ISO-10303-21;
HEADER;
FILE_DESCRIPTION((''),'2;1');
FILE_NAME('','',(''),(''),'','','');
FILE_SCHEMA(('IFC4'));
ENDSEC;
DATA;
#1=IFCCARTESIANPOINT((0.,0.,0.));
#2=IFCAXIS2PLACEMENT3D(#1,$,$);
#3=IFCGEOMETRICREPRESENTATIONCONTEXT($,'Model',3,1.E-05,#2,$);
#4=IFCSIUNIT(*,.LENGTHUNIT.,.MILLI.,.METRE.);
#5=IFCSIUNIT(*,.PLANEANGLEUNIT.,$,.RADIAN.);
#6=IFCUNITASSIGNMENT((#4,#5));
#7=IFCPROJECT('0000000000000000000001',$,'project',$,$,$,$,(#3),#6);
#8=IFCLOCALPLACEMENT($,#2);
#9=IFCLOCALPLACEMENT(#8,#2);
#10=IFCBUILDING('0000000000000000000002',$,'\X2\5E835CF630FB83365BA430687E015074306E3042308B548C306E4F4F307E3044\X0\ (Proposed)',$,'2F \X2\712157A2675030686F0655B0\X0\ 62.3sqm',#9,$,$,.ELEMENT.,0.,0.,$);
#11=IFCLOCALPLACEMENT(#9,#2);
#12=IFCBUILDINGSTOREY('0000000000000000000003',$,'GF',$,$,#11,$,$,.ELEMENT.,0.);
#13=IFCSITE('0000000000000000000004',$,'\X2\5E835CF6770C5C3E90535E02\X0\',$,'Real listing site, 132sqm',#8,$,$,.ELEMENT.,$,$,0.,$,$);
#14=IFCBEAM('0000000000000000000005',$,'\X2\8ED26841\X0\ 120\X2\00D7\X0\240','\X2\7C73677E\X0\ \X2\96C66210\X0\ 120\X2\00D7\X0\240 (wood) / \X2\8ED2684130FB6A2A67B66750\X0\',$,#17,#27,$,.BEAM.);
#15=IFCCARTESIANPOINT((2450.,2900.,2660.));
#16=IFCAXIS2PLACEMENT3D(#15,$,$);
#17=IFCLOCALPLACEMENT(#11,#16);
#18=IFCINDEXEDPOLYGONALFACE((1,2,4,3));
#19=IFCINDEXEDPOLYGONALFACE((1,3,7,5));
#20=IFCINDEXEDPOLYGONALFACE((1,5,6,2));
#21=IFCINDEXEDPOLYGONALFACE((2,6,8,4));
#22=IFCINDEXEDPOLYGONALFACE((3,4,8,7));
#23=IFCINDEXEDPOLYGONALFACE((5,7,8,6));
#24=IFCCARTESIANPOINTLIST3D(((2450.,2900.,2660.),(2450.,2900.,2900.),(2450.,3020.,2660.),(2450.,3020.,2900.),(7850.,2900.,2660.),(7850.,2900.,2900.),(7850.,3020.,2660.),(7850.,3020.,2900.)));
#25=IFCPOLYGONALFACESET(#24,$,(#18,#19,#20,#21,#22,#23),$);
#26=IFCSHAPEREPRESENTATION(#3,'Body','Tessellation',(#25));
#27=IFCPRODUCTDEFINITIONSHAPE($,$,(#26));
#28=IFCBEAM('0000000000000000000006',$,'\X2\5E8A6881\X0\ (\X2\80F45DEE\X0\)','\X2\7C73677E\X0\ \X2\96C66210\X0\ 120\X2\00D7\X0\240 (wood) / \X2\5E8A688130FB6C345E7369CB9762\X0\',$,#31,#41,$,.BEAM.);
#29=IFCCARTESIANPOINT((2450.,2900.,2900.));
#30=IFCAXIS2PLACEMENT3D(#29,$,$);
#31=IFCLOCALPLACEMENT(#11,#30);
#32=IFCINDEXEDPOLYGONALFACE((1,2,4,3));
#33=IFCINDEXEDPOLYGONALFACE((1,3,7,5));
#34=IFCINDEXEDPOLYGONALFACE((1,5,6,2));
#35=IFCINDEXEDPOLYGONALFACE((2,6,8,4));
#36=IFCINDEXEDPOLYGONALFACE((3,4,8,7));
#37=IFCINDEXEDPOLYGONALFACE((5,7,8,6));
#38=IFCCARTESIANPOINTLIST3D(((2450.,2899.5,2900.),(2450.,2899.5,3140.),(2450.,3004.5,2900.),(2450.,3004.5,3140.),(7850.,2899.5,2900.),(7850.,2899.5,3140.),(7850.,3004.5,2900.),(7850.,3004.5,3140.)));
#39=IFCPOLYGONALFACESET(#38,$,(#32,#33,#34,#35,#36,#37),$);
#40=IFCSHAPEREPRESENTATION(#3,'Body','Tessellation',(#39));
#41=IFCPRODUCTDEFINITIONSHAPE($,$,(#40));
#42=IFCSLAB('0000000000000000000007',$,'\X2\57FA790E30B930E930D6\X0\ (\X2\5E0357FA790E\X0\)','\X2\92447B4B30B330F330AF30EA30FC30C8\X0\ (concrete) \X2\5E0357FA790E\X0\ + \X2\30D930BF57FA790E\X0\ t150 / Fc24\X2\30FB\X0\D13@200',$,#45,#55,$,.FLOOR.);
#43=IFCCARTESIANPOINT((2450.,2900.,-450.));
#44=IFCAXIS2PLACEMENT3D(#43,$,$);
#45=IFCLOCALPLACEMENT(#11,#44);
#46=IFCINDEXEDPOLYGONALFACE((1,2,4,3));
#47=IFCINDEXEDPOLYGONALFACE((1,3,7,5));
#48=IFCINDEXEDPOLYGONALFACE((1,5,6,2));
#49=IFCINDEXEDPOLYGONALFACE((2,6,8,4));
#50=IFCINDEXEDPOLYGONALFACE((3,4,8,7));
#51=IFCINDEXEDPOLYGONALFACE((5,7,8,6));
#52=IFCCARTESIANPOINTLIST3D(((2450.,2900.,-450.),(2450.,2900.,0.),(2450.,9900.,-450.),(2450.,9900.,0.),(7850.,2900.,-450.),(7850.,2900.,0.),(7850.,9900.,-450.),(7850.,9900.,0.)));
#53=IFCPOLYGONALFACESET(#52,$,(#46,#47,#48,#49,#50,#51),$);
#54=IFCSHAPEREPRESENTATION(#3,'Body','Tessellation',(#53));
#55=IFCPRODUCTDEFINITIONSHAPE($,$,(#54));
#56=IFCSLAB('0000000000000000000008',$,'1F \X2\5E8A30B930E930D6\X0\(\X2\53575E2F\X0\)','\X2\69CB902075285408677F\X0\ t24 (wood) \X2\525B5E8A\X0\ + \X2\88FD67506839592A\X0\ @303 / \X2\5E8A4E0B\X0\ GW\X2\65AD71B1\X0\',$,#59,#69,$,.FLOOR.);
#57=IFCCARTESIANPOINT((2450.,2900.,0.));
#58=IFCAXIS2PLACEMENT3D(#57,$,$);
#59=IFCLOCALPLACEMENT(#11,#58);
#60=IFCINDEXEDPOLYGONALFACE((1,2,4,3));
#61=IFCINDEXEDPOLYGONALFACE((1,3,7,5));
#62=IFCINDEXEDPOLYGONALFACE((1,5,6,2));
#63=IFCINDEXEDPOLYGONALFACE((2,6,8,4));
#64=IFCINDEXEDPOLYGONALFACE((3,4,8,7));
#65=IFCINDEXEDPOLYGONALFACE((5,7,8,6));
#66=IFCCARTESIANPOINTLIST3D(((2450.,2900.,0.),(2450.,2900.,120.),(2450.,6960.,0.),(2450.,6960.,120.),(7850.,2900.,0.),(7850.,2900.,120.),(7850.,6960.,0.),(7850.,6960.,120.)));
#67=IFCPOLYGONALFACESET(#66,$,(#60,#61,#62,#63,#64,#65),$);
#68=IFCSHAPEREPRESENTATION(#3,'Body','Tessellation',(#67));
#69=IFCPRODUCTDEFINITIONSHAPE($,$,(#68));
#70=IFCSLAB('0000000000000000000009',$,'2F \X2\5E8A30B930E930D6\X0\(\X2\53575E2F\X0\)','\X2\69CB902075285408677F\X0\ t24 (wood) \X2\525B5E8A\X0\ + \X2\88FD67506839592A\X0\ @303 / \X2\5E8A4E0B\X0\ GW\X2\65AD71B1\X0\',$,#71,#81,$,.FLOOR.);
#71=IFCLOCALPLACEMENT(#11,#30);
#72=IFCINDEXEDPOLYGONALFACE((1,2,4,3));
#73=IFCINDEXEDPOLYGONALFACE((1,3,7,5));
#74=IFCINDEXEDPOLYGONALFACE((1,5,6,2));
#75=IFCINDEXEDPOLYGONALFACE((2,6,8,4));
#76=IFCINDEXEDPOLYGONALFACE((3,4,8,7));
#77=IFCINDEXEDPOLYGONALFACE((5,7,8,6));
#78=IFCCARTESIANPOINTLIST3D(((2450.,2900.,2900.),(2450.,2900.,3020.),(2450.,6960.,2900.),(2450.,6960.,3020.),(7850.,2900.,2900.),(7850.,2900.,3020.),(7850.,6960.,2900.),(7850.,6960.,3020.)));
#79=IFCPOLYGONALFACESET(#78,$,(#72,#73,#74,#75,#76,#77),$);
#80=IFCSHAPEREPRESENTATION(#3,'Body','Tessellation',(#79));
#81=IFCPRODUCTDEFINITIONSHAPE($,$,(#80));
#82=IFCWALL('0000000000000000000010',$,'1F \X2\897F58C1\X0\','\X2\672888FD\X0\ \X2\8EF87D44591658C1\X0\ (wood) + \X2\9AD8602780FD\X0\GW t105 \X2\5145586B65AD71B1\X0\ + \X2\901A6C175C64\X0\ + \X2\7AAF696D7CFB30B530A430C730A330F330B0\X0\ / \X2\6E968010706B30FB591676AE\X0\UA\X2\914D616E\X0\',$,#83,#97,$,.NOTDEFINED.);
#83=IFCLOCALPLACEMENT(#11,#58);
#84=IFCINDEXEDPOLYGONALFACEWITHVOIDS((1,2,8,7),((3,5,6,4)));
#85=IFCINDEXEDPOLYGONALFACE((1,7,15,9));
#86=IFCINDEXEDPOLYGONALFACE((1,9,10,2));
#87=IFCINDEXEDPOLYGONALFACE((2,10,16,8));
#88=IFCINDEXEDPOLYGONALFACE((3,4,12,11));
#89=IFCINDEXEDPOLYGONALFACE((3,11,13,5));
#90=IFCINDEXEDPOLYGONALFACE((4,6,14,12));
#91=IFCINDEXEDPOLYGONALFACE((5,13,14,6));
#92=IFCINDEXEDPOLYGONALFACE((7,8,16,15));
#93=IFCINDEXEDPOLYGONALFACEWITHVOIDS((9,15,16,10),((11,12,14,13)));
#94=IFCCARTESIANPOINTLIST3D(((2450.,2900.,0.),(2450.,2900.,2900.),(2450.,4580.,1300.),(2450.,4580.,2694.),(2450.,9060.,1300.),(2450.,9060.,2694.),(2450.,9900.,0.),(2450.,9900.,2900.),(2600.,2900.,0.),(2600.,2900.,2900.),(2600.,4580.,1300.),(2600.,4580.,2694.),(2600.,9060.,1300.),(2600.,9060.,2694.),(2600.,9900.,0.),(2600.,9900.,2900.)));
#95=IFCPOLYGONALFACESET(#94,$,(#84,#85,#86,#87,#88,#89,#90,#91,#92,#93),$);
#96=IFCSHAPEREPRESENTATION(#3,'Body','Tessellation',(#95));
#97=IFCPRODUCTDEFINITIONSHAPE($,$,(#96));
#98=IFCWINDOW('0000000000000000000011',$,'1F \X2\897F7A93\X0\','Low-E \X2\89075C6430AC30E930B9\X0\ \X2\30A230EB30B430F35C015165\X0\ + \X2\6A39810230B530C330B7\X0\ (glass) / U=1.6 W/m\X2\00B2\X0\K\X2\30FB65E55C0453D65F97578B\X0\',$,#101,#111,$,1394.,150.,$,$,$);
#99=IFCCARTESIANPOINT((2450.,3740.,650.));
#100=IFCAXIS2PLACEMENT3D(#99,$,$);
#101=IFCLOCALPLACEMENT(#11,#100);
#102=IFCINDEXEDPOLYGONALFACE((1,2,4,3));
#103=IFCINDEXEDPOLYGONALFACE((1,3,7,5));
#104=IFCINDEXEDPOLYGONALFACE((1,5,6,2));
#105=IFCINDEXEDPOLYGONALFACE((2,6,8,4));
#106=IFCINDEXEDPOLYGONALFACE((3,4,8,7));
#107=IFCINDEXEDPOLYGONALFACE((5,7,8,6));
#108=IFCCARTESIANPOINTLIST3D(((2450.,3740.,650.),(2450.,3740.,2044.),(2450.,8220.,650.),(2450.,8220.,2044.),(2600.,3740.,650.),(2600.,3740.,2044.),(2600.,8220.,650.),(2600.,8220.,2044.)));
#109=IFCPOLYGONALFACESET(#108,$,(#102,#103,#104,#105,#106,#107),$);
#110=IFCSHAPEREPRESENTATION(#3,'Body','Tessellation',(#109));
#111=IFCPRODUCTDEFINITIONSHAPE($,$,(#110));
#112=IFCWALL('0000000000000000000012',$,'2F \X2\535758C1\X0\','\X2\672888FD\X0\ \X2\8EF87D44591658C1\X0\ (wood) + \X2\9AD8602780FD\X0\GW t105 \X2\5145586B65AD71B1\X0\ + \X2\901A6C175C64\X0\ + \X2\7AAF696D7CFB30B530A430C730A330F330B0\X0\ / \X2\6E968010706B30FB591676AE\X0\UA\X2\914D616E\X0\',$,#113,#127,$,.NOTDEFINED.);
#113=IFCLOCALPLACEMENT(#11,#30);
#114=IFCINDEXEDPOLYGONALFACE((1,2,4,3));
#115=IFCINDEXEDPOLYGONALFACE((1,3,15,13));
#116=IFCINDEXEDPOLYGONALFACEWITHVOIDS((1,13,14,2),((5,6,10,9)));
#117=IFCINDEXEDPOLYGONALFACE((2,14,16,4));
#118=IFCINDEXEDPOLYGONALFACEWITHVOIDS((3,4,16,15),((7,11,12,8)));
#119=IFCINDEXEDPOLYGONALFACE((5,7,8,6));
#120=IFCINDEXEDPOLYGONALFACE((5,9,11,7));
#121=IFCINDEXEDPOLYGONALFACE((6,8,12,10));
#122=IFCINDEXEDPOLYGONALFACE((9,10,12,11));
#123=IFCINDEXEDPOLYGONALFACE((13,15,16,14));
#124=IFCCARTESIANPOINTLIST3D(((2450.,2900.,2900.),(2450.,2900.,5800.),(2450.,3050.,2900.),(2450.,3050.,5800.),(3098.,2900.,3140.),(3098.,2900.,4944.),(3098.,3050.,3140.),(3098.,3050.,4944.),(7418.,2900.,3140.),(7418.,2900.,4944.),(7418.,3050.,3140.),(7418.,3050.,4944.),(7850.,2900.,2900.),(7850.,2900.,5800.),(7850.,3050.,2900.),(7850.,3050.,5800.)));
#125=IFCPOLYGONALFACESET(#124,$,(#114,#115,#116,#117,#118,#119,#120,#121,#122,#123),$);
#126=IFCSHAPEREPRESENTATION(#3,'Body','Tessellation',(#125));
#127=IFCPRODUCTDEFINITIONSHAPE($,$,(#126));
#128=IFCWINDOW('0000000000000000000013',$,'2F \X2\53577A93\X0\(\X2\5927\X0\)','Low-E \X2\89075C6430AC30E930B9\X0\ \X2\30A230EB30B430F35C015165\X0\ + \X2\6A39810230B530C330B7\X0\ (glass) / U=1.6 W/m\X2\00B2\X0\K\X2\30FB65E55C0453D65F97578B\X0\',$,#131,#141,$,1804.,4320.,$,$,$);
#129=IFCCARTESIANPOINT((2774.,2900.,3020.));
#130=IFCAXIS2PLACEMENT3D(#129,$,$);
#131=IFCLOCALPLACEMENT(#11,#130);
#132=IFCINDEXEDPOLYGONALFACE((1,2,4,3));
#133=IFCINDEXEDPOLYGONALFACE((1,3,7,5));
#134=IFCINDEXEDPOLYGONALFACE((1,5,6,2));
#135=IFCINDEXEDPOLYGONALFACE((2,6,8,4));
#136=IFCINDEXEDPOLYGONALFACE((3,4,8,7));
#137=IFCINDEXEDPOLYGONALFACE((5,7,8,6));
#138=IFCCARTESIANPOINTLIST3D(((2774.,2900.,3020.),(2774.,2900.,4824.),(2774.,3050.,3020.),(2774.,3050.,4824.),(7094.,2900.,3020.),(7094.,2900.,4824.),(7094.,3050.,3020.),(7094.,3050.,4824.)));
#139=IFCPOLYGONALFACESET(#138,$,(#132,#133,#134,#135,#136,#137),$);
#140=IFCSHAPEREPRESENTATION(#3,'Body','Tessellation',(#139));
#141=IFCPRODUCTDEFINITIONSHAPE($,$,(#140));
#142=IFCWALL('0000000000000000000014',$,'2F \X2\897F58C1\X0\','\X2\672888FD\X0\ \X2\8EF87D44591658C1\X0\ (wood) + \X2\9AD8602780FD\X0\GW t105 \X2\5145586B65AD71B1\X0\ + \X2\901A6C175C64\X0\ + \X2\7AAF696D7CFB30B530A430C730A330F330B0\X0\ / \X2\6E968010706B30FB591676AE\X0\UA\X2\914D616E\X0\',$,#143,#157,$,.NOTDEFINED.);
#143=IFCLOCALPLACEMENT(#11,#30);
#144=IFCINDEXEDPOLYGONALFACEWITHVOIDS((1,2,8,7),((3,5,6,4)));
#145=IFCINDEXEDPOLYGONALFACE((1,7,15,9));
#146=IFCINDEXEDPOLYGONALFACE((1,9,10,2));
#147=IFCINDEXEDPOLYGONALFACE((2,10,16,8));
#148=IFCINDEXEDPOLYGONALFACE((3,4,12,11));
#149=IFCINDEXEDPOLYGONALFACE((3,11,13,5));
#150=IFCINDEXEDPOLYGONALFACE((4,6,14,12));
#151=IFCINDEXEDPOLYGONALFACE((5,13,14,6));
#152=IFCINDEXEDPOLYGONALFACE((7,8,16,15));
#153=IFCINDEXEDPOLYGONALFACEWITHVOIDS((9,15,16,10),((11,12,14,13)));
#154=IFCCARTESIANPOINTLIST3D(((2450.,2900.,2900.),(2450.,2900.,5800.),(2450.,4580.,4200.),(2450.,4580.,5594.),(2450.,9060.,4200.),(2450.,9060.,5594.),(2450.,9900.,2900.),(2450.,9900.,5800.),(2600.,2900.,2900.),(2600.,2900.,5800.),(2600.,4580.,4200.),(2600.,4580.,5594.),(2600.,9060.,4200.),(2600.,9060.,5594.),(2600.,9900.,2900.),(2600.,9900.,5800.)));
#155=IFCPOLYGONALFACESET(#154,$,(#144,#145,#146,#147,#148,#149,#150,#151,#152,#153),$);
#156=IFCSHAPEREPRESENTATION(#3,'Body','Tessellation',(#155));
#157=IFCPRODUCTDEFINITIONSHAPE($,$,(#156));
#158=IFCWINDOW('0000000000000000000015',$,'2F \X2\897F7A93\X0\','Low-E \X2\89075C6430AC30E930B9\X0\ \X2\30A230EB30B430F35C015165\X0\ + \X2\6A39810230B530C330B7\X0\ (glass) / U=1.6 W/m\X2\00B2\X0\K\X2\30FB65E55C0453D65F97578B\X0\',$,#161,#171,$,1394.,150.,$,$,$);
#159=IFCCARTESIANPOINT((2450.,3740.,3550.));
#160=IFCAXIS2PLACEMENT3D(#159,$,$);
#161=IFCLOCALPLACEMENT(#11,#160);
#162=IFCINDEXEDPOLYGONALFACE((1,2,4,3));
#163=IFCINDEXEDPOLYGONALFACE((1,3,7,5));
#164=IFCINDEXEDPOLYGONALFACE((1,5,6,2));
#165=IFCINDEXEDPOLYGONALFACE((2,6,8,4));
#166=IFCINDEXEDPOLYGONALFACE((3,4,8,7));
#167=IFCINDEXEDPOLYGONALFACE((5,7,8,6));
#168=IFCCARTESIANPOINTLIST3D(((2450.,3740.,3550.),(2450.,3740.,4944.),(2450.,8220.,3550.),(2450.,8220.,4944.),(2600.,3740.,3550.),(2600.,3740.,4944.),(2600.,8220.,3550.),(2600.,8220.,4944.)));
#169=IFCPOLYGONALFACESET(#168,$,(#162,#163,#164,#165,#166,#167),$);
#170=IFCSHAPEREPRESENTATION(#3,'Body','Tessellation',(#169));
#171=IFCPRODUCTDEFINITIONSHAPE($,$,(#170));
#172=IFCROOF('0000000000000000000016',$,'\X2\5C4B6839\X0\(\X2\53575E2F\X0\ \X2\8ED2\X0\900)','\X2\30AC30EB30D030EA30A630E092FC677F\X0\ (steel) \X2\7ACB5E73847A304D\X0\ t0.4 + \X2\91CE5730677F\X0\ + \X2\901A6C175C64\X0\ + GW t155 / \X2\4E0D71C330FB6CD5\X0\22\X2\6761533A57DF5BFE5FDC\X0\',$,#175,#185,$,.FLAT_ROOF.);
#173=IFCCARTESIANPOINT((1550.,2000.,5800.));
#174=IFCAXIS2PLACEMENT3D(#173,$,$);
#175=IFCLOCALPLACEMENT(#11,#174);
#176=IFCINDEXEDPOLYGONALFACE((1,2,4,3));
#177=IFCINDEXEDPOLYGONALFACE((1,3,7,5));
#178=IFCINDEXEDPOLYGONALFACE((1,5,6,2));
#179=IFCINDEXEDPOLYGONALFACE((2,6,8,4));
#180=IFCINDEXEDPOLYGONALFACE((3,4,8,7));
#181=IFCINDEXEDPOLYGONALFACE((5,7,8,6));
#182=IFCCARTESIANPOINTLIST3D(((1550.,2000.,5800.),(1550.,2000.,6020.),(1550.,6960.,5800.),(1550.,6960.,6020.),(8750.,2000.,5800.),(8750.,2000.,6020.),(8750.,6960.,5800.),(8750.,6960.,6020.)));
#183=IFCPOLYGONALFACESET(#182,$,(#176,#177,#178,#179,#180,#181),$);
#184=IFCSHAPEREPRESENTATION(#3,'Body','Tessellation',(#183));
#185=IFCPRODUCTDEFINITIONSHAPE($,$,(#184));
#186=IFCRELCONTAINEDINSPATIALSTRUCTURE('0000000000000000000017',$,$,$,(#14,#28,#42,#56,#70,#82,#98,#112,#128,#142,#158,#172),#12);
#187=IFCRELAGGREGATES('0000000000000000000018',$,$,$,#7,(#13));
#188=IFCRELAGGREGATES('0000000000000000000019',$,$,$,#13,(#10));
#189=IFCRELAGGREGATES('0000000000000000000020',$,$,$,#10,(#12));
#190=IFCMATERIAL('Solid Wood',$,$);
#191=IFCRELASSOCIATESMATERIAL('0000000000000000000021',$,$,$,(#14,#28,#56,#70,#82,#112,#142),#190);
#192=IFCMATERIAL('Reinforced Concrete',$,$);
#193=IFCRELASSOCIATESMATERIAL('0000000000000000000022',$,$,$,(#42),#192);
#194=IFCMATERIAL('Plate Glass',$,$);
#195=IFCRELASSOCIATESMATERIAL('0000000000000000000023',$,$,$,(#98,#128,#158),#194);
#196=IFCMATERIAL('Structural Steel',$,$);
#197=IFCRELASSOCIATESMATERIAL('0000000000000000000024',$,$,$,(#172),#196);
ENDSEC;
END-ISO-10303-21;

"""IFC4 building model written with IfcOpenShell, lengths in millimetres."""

from ifc_helpers import new_model, si_unit, frame, frame_2d, origin, place, context, project, spatial, rectangle, extrude, material, element, fill, save


model = new_model("IFC4")

# Units and contexts
model_context = context("Model", 3, precision=1e-05, world=origin())
ifc_project = project(units=[si_unit("LENGTHUNIT", "METRE", prefix="MILLI"), si_unit("PLANEANGLEUNIT", "RADIAN")], contexts=[model_context])

# Site, building, storey
site_placement = place(None, origin())
site = spatial("IfcSite", under=ifc_project, at=site_placement, Name="広島県尾道市", ObjectType="Real listing site, 132sqm", CompositionType="ELEMENT", RefElevation=0.0)
building_placement = place(site_placement, origin())
building = spatial("IfcBuilding", under=site, at=building_placement, Name="広島・茶室と縁側のある和の住まい (Proposed)", ObjectType="2F 無垢材と漆喰 62.3sqm", CompositionType="ELEMENT", ElevationOfRefHeight=0.0, ElevationOfTerrain=0.0)
storey_placement = place(building_placement, origin())
storey = spatial("IfcBuildingStorey", under=building, at=storey_placement, Name="GF", CompositionType="ELEMENT", Elevation=0.0)

# Shared definitions
ifc_material_1 = material(Name="Solid Wood")

# Beams
beam_1_placement = place(storey_placement, frame((2450.0, 2900.0, 2660.0)))
element("IfcBeam", 1, at=beam_1_placement, inside=storey, material=ifc_material_1, Name="軒桁 120×240", Description="米松 集成 120×240 (wood) / 軒桁・横架材", PredefinedType="BEAM", context=model_context, shape_type="SweptSolid", body=[
    extrude(rectangle(XDim=5400.0, YDim=120.0, at=frame_2d((2700.0, 60.0))), frame((2450.0, 2900.0, 2660.0)), (0.0, 0.0, 1.0), 240.0),
])
beam_2_placement = place(storey_placement, frame((2450.0, 2900.0, 2900.0)))
element("IfcBeam", 2, at=beam_2_placement, inside=storey, material=ifc_material_1, Name="床梁 (胴差)", Description="米松 集成 120×240 (wood) / 床梁・水平構面", PredefinedType="BEAM", context=model_context, shape_type="SweptSolid", body=[
    extrude(rectangle(XDim=5400.0, YDim=105.0, at=frame_2d((2700.0, 52.0))), frame((2450.0, 2900.0, 2900.0)), (0.0, 0.0, 1.0), 240.0),
])

# Slabs
ifc_material_2 = material(Name="Reinforced Concrete")
slab_1_placement = place(storey_placement, frame((2450.0, 2900.0, -450.0)))
element("IfcSlab", 3, at=slab_1_placement, inside=storey, material=ifc_material_2, Name="基礎スラブ (布基礎)", Description="鉄筋コンクリート (concrete) 布基礎 + ベタ基礎 t150 / Fc24・D13@200", PredefinedType="FLOOR", context=model_context, shape_type="SweptSolid", body=[
    extrude(rectangle(XDim=5400.0, YDim=7000.0, at=frame_2d((2700.0, 3500.0))), frame((2450.0, 2900.0, -450.0)), (0.0, 0.0, 1.0), 450.0),
])
slab_2_placement = place(storey_placement, frame((2450.0, 2900.0, 0.0)))
element("IfcSlab", 4, at=slab_2_placement, inside=storey, material=ifc_material_1, Name="1F 床スラブ(南帯)", Description="構造用合板 t24 (wood) 剛床 + 製材根太 @303 / 床下 GW断熱", PredefinedType="FLOOR", context=model_context, shape_type="SweptSolid", body=[
    extrude(rectangle(XDim=5400.0, YDim=4060.0, at=frame_2d((2700.0, 2030.0))), frame((2450.0, 2900.0, 0.0)), (0.0, 0.0, 1.0), 120.0),
])
slab_3_placement = place(storey_placement, frame((2450.0, 2900.0, 2900.0)))
element("IfcSlab", 5, at=slab_3_placement, inside=storey, material=ifc_material_1, Name="2F 床スラブ(南帯)", Description="構造用合板 t24 (wood) 剛床 + 製材根太 @303 / 床下 GW断熱", PredefinedType="FLOOR", context=model_context, shape_type="SweptSolid", body=[
    extrude(rectangle(XDim=5400.0, YDim=4060.0, at=frame_2d((2700.0, 2030.0))), frame((2450.0, 2900.0, 2900.0)), (0.0, 0.0, 1.0), 120.0),
])

# Shared definitions
ifc_material_3 = material(Name="Plate Glass")

# Walls, openings, windows
wall_1_placement = place(storey_placement, frame((2450.0, 2900.0, 0.0)))
wall_1 = element("IfcWall", 6, at=wall_1_placement, inside=storey, material=ifc_material_1, Name="1F 西壁", Description="木製 軸組外壁 (wood) + 高性能GW t105 充填断熱 + 通気層 + 窯業系サイディング / 準耐火・外皮UA配慮", PredefinedType="NOTDEFINED", context=model_context, shape_type="SweptSolid", body=[
    extrude(rectangle(XDim=150.0, YDim=7000.0, at=frame_2d((75.0, 3500.0))), frame((2450.0, 2900.0, 0.0)), (0.0, 0.0, 1.0), 2900.0),
])
opening_1_placement = place(storey_placement, frame((2450.0, 3740.0, 650.0)))
opening_1 = element("IfcOpeningElement", 7, at=opening_1_placement, cuts=wall_1, PredefinedType="NOTDEFINED", context=model_context, shape_type="SweptSolid", body=[
    extrude(rectangle(XDim=150.0, YDim=4480.0, at=frame_2d((75.0, 2240.0))), frame((2450.0, 3740.0, 650.0)), (0.0, 0.0, 1.0), 1394.0),
])
window_1_placement = place(storey_placement, frame((2450.0, 3740.0, 650.0)))
window_1 = element("IfcWindow", 8, at=window_1_placement, inside=storey, material=ifc_material_3, Name="1F 西窓", Description="Low-E 複層ガラス アルゴン封入 + 樹脂サッシ (glass) / U=1.6 W/m²K・日射取得型", OverallHeight=1394.0, OverallWidth=150.0, context=model_context, shape_type="SweptSolid", body=[
    extrude(rectangle(XDim=150.0, YDim=4480.0, at=frame_2d((75.0, 2240.0))), frame((2450.0, 3740.0, 650.0)), (0.0, 0.0, 1.0), 1394.0),
])
fill(opening_1, window_1)
wall_2_placement = place(storey_placement, frame((2450.0, 2900.0, 2900.0)))
wall_2 = element("IfcWall", 9, at=wall_2_placement, inside=storey, material=ifc_material_1, Name="2F 南壁", Description="木製 軸組外壁 (wood) + 高性能GW t105 充填断熱 + 通気層 + 窯業系サイディング / 準耐火・外皮UA配慮", PredefinedType="NOTDEFINED", context=model_context, shape_type="SweptSolid", body=[
    extrude(rectangle(XDim=5400.0, YDim=150.0, at=frame_2d((2700.0, 75.0))), frame((2450.0, 2900.0, 2900.0)), (0.0, 0.0, 1.0), 2900.0),
])
opening_2_placement = place(storey_placement, frame((2774.0, 2900.0, 3020.0)))
opening_2 = element("IfcOpeningElement", 10, at=opening_2_placement, cuts=wall_2, PredefinedType="NOTDEFINED", context=model_context, shape_type="SweptSolid", body=[
    extrude(rectangle(XDim=4320.0, YDim=150.0, at=frame_2d((2160.0, 75.0))), frame((2774.0, 2900.0, 3020.0)), (0.0, 0.0, 1.0), 1804.0),
])
window_2_placement = place(storey_placement, frame((2774.0, 2900.0, 3020.0)))
window_2 = element("IfcWindow", 11, at=window_2_placement, inside=storey, material=ifc_material_3, Name="2F 南窓(大)", Description="Low-E 複層ガラス アルゴン封入 + 樹脂サッシ (glass) / U=1.6 W/m²K・日射取得型", OverallHeight=1804.0, OverallWidth=4320.0, context=model_context, shape_type="SweptSolid", body=[
    extrude(rectangle(XDim=4320.0, YDim=150.0, at=frame_2d((2160.0, 75.0))), frame((2774.0, 2900.0, 3020.0)), (0.0, 0.0, 1.0), 1804.0),
])
fill(opening_2, window_2)
wall_3_placement = place(storey_placement, frame((2450.0, 2900.0, 2900.0)))
wall_3 = element("IfcWall", 12, at=wall_3_placement, inside=storey, material=ifc_material_1, Name="2F 西壁", Description="木製 軸組外壁 (wood) + 高性能GW t105 充填断熱 + 通気層 + 窯業系サイディング / 準耐火・外皮UA配慮", PredefinedType="NOTDEFINED", context=model_context, shape_type="SweptSolid", body=[
    extrude(rectangle(XDim=150.0, YDim=7000.0, at=frame_2d((75.0, 3500.0))), frame((2450.0, 2900.0, 2900.0)), (0.0, 0.0, 1.0), 2900.0),
])
opening_3_placement = place(storey_placement, frame((2450.0, 3740.0, 3550.0)))
opening_3 = element("IfcOpeningElement", 13, at=opening_3_placement, cuts=wall_3, PredefinedType="NOTDEFINED", context=model_context, shape_type="SweptSolid", body=[
    extrude(rectangle(XDim=150.0, YDim=4480.0, at=frame_2d((75.0, 2240.0))), frame((2450.0, 3740.0, 3550.0)), (0.0, 0.0, 1.0), 1394.0),
])
window_3_placement = place(storey_placement, frame((2450.0, 3740.0, 3550.0)))
window_3 = element("IfcWindow", 14, at=window_3_placement, inside=storey, material=ifc_material_3, Name="2F 西窓", Description="Low-E 複層ガラス アルゴン封入 + 樹脂サッシ (glass) / U=1.6 W/m²K・日射取得型", OverallHeight=1394.0, OverallWidth=150.0, context=model_context, shape_type="SweptSolid", body=[
    extrude(rectangle(XDim=150.0, YDim=4480.0, at=frame_2d((75.0, 2240.0))), frame((2450.0, 3740.0, 3550.0)), (0.0, 0.0, 1.0), 1394.0),
])
fill(opening_3, window_3)

# Roof
ifc_material_4 = material(Name="Structural Steel")
for number, where, name in (
    (15, (1550.0, 2000.0, 5800.0), "屋根(南帯 軒900)"),
):
    element("IfcRoof", number, at=place(storey_placement, frame(where)), inside=storey, material=ifc_material_4, Name=name, Description="ガルバリウム鋼板 (steel) 立平葺き t0.4 + 野地板 + 通気層 + GW t155 / 不燃・法22条区域対応", PredefinedType="FLAT_ROOF", context=model_context, shape_type="SweptSolid", body=[
        extrude(rectangle(XDim=7200.0, YDim=4960.0, at=frame_2d((3600.0, 2480.0))), frame((1550.0, 2000.0, 5800.0)), (0.0, 0.0, 1.0), 220.0),
    ])

save(model, "model.ifc")
